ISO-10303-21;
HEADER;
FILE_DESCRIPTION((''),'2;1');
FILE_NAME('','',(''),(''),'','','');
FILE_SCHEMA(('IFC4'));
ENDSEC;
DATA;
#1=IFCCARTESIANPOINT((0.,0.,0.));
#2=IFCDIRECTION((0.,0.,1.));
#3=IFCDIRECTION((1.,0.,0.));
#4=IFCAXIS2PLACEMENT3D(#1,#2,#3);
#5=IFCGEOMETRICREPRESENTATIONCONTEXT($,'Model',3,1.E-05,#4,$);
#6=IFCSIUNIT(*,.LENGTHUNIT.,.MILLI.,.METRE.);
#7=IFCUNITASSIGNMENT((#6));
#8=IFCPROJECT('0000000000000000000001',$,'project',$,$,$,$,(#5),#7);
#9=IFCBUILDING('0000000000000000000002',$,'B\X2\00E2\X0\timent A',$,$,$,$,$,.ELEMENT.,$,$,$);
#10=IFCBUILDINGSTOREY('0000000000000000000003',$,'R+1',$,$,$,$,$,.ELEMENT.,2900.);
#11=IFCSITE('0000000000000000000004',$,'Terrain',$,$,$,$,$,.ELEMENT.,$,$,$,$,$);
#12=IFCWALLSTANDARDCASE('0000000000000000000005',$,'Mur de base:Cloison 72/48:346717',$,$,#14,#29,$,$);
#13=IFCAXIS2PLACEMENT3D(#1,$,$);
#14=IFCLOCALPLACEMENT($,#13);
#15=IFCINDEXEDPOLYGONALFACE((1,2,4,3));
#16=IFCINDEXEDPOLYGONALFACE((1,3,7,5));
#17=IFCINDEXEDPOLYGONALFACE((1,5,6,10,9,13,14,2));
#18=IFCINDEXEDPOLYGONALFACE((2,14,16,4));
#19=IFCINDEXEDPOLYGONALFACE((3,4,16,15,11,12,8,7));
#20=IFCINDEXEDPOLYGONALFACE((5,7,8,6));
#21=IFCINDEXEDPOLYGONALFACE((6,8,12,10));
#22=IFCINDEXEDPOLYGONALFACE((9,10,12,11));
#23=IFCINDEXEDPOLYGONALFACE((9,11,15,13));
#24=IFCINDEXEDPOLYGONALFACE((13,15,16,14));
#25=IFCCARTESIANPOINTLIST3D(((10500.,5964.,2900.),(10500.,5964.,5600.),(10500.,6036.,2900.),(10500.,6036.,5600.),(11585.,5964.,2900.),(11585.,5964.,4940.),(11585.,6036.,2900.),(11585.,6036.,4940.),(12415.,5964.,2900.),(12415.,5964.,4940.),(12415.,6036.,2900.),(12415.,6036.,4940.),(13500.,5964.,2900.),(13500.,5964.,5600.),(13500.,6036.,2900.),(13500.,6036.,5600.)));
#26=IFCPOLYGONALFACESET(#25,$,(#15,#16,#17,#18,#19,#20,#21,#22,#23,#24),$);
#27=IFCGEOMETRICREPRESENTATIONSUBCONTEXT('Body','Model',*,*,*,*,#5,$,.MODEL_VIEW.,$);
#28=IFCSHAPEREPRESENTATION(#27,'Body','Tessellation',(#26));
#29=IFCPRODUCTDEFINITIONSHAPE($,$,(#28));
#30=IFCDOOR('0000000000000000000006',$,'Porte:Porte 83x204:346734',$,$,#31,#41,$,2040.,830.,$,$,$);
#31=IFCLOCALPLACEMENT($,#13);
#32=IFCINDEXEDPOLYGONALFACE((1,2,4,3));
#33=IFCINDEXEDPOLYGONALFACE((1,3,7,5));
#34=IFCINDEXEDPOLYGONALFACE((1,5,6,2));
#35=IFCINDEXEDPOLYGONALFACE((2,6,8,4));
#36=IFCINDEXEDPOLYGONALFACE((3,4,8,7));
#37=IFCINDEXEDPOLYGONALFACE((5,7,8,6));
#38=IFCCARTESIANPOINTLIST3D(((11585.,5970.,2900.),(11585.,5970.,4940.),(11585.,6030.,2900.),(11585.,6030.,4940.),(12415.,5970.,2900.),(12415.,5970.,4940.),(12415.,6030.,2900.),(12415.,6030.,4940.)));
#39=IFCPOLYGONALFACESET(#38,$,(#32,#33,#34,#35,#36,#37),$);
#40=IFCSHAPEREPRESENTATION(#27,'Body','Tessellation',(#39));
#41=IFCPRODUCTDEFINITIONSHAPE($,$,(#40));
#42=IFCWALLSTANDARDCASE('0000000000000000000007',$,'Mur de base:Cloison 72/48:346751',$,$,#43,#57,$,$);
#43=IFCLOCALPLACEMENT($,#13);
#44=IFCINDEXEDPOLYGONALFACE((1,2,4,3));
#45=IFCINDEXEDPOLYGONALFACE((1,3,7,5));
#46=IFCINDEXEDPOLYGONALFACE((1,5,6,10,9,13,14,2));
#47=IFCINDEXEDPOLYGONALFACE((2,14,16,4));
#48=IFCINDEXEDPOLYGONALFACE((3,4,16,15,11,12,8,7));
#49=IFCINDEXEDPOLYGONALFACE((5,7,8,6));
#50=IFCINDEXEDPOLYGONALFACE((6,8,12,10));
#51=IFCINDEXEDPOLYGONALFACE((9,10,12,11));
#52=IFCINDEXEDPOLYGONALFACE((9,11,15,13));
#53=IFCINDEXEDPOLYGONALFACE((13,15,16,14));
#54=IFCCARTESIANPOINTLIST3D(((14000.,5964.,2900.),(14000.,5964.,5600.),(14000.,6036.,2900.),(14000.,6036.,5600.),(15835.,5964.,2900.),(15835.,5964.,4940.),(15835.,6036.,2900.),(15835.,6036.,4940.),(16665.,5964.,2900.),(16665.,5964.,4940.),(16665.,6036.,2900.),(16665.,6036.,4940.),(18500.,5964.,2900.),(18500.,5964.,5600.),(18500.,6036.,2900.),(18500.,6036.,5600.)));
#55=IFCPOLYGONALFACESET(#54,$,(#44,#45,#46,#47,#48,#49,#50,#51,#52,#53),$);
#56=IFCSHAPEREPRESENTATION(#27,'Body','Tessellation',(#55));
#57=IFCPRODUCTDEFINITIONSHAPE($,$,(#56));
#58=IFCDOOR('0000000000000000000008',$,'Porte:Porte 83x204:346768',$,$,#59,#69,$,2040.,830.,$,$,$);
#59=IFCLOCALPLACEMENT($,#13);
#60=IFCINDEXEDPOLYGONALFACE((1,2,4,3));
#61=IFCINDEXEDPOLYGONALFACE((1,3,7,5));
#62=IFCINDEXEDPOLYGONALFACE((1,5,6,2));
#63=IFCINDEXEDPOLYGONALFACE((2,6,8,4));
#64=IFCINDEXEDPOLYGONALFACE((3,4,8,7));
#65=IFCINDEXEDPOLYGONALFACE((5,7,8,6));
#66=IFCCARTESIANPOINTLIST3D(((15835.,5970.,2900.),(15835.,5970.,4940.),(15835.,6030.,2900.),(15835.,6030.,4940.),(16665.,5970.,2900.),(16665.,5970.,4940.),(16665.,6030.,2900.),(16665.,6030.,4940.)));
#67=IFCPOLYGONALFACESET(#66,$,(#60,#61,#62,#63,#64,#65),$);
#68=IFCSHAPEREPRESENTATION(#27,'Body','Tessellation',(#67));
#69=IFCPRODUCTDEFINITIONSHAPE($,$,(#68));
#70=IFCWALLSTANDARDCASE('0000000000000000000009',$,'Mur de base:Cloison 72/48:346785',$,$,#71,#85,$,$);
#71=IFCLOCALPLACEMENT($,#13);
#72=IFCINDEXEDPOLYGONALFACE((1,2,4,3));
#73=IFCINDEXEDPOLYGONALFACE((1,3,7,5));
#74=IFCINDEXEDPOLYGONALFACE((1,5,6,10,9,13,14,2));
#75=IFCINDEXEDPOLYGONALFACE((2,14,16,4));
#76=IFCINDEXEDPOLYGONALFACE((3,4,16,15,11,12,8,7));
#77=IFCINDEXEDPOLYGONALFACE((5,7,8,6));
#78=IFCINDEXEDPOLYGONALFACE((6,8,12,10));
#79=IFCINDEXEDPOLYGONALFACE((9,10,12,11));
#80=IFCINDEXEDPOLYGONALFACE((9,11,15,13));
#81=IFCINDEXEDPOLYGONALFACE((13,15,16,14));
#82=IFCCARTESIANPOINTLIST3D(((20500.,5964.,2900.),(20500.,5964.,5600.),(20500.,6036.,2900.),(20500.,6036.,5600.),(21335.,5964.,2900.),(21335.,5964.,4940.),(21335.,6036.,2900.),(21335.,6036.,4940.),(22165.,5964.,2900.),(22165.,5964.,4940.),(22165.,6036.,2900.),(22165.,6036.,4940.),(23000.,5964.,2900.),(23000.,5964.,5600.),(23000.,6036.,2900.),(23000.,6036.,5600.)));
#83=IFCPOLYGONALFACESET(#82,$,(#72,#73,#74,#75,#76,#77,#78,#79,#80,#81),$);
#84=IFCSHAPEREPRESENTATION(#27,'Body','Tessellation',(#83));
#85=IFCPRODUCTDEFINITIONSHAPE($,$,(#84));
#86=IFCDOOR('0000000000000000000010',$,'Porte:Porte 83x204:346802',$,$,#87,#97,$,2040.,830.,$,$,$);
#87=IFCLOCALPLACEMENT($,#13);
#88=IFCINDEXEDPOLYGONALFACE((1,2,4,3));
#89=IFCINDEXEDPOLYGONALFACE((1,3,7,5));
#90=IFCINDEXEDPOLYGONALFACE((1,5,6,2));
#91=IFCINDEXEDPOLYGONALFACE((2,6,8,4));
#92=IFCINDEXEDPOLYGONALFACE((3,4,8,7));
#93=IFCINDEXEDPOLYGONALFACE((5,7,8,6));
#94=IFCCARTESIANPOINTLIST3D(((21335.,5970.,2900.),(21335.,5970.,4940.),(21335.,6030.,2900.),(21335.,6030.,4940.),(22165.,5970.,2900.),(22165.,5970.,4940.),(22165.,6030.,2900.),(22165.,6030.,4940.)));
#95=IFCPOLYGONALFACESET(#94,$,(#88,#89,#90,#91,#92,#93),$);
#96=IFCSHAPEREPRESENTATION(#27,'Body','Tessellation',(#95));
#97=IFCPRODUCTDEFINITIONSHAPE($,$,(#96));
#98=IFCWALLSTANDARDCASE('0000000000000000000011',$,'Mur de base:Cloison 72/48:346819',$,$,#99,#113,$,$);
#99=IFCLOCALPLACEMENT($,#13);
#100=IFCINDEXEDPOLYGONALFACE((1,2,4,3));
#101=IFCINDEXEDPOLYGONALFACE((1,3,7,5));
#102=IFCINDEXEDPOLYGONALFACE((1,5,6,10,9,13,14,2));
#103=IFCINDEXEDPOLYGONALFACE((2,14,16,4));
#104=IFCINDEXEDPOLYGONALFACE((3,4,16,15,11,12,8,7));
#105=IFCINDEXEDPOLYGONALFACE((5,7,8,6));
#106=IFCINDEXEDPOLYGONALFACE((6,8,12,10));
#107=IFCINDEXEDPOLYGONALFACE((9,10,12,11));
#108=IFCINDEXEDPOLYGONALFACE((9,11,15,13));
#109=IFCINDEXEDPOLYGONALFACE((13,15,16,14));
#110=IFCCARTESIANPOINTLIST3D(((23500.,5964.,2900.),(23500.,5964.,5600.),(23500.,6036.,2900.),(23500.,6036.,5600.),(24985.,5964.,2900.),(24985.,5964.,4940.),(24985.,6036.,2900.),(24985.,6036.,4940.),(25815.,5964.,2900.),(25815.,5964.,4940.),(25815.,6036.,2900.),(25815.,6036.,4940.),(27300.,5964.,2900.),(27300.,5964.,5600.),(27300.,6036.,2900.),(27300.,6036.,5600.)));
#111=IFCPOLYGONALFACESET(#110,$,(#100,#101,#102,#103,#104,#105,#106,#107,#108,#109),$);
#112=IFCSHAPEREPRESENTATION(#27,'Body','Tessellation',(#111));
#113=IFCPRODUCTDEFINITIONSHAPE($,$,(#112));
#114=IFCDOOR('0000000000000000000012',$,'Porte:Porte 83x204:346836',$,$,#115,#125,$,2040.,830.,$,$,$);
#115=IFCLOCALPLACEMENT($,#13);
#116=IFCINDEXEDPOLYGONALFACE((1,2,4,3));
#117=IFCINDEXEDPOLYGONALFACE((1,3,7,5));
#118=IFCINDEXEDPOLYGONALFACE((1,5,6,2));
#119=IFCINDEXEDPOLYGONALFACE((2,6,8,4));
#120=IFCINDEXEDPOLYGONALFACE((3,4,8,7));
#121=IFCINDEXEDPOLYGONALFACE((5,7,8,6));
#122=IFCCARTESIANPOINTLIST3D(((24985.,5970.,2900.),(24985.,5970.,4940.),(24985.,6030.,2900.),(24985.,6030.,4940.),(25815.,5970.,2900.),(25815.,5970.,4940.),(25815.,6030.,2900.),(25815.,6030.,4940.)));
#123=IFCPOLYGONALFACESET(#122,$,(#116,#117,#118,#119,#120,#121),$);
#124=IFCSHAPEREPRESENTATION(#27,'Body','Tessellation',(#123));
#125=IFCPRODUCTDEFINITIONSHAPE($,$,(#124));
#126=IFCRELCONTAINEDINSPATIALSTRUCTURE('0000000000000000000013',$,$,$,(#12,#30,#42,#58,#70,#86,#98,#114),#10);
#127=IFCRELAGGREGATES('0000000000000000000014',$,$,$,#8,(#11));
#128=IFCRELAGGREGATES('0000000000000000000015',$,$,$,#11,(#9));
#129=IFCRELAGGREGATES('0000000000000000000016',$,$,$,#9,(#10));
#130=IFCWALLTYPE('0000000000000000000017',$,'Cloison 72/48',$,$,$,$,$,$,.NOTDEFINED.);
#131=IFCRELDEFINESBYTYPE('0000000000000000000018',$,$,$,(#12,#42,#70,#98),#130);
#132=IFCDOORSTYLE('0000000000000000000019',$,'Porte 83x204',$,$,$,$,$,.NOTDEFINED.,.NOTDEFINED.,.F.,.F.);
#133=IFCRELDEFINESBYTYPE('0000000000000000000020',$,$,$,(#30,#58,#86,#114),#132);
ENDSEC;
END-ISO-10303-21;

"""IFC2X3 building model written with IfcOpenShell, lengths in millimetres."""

from ifc_helpers import new_model, si_unit, frame, frame_2d, origin_with_axes, place, context, subcontext, project, spatial, rectangle, extrude, type_object, element, fill, save


model = new_model("IFC2X3")

# Units and contexts
model_context = context("Model", 3, precision=1e-05, world=origin_with_axes())
body_context = subcontext(model_context, "Body", "Model", "MODEL_VIEW")
ifc_project = project(units=[si_unit("LENGTHUNIT", "METRE", prefix="MILLI")], contexts=[model_context])

# Site, building, storey
site = spatial("IfcSite", under=ifc_project, Name="Terrain", CompositionType="ELEMENT")
building = spatial("IfcBuilding", under=site, Name="Bâtiment A", CompositionType="ELEMENT")
storey = spatial("IfcBuildingStorey", under=building, Name="R+1", CompositionType="ELEMENT", Elevation=2900.0)

# Walls, openings, doors
door_style = type_object("IfcDoorStyle", Name="Porte 83x204", ConstructionType="NOTDEFINED", OperationType="NOTDEFINED", ParameterTakesPrecedence=False, Sizeable=False)
wall_type_1 = type_object("IfcWallType", Name="Cloison 72/48", PredefinedType="NOTDEFINED")
wall_1_placement = place(None, origin_with_axes())
wall_1 = element("IfcWallStandardCase", 1, at=wall_1_placement, inside=storey, type_object=wall_type_1, Name="Mur de base:Cloison 72/48:346717", context=body_context, shape_type="SweptSolid", body=[
    extrude(rectangle(XDim=3000.0, YDim=72.0, at=frame_2d((12000.0, 6000.0))), frame((0.0, 0.0, 2900.0), z_axis=(0.0, 0.0, 1.0), x_axis=(1.0, 0.0, 0.0)), (0.0, 0.0, 1.0), 2700.0),
])
opening_1_placement = place(None, origin_with_axes())
opening_1 = element("IfcOpeningElement", 2, at=opening_1_placement, cuts=wall_1, context=body_context, shape_type="SweptSolid", body=[
    extrude(rectangle(XDim=830.0, YDim=192.0, at=frame_2d((12000.0, 6000.0))), frame((0.0, 0.0, 2900.0), z_axis=(0.0, 0.0, 1.0), x_axis=(1.0, 0.0, 0.0)), (0.0, 0.0, 1.0), 2040.0),
])
door_1_placement = place(None, origin_with_axes())
door_1 = element("IfcDoor", 3, at=door_1_placement, inside=storey, type_object=door_style, Name="Porte:Porte 83x204:346734", OverallHeight=2040.0, OverallWidth=830.0, context=body_context, shape_type="SweptSolid", body=[
    extrude(rectangle(XDim=830.0, YDim=60.0, at=frame_2d((12000.0, 6000.0))), frame((0.0, 0.0, 2900.0), z_axis=(0.0, 0.0, 1.0), x_axis=(1.0, 0.0, 0.0)), (0.0, 0.0, 1.0), 2040.0),
])
fill(opening_1, door_1)
wall_2_placement = place(None, origin_with_axes())
wall_2 = element("IfcWallStandardCase", 4, at=wall_2_placement, inside=storey, type_object=wall_type_1, Name="Mur de base:Cloison 72/48:346751", context=body_context, shape_type="SweptSolid", body=[
    extrude(rectangle(XDim=4500.0, YDim=72.0, at=frame_2d((16250.0, 6000.0))), frame((0.0, 0.0, 2900.0), z_axis=(0.0, 0.0, 1.0), x_axis=(1.0, 0.0, 0.0)), (0.0, 0.0, 1.0), 2700.0),
])
opening_2_placement = place(None, origin_with_axes())
opening_2 = element("IfcOpeningElement", 5, at=opening_2_placement, cuts=wall_2, context=body_context, shape_type="SweptSolid", body=[
    extrude(rectangle(XDim=830.0, YDim=192.0, at=frame_2d((16250.0, 6000.0))), frame((0.0, 0.0, 2900.0), z_axis=(0.0, 0.0, 1.0), x_axis=(1.0, 0.0, 0.0)), (0.0, 0.0, 1.0), 2040.0),
])
door_2_placement = place(None, origin_with_axes())
door_2 = element("IfcDoor", 6, at=door_2_placement, inside=storey, type_object=door_style, Name="Porte:Porte 83x204:346768", OverallHeight=2040.0, OverallWidth=830.0, context=body_context, shape_type="SweptSolid", body=[
    extrude(rectangle(XDim=830.0, YDim=60.0, at=frame_2d((16250.0, 6000.0))), frame((0.0, 0.0, 2900.0), z_axis=(0.0, 0.0, 1.0), x_axis=(1.0, 0.0, 0.0)), (0.0, 0.0, 1.0), 2040.0),
])
fill(opening_2, door_2)
wall_3_placement = place(None, origin_with_axes())
wall_3 = element("IfcWallStandardCase", 7, at=wall_3_placement, inside=storey, type_object=wall_type_1, Name="Mur de base:Cloison 72/48:346785", context=body_context, shape_type="SweptSolid", body=[
    extrude(rectangle(XDim=2500.0, YDim=72.0, at=frame_2d((21750.0, 6000.0))), frame((0.0, 0.0, 2900.0), z_axis=(0.0, 0.0, 1.0), x_axis=(1.0, 0.0, 0.0)), (0.0, 0.0, 1.0), 2700.0),
])
opening_3_placement = place(None, origin_with_axes())
opening_3 = element("IfcOpeningElement", 8, at=opening_3_placement, cuts=wall_3, context=body_context, shape_type="SweptSolid", body=[
    extrude(rectangle(XDim=830.0, YDim=192.0, at=frame_2d((21750.0, 6000.0))), frame((0.0, 0.0, 2900.0), z_axis=(0.0, 0.0, 1.0), x_axis=(1.0, 0.0, 0.0)), (0.0, 0.0, 1.0), 2040.0),
])
door_3_placement = place(None, origin_with_axes())
door_3 = element("IfcDoor", 9, at=door_3_placement, inside=storey, type_object=door_style, Name="Porte:Porte 83x204:346802", OverallHeight=2040.0, OverallWidth=830.0, context=body_context, shape_type="SweptSolid", body=[
    extrude(rectangle(XDim=830.0, YDim=60.0, at=frame_2d((21750.0, 6000.0))), frame((0.0, 0.0, 2900.0), z_axis=(0.0, 0.0, 1.0), x_axis=(1.0, 0.0, 0.0)), (0.0, 0.0, 1.0), 2040.0),
])
fill(opening_3, door_3)
wall_4_placement = place(None, origin_with_axes())
wall_4 = element("IfcWallStandardCase", 10, at=wall_4_placement, inside=storey, type_object=wall_type_1, Name="Mur de base:Cloison 72/48:346819", context=body_context, shape_type="SweptSolid", body=[
    extrude(rectangle(XDim=3800.0, YDim=72.0, at=frame_2d((25400.0, 6000.0))), frame((0.0, 0.0, 2900.0), z_axis=(0.0, 0.0, 1.0), x_axis=(1.0, 0.0, 0.0)), (0.0, 0.0, 1.0), 2700.0),
])
opening_4_placement = place(None, origin_with_axes())
opening_4 = element("IfcOpeningElement", 11, at=opening_4_placement, cuts=wall_4, context=body_context, shape_type="SweptSolid", body=[
    extrude(rectangle(XDim=830.0, YDim=192.0, at=frame_2d((25400.0, 6000.0))), frame((0.0, 0.0, 2900.0), z_axis=(0.0, 0.0, 1.0), x_axis=(1.0, 0.0, 0.0)), (0.0, 0.0, 1.0), 2040.0),
])
door_4_placement = place(None, origin_with_axes())
door_4 = element("IfcDoor", 12, at=door_4_placement, inside=storey, type_object=door_style, Name="Porte:Porte 83x204:346836", OverallHeight=2040.0, OverallWidth=830.0, context=body_context, shape_type="SweptSolid", body=[
    extrude(rectangle(XDim=830.0, YDim=60.0, at=frame_2d((25400.0, 6000.0))), frame((0.0, 0.0, 2900.0), z_axis=(0.0, 0.0, 1.0), x_axis=(1.0, 0.0, 0.0)), (0.0, 0.0, 1.0), 2040.0),
])
fill(opening_4, door_4)

save(model, "model.ifc")
